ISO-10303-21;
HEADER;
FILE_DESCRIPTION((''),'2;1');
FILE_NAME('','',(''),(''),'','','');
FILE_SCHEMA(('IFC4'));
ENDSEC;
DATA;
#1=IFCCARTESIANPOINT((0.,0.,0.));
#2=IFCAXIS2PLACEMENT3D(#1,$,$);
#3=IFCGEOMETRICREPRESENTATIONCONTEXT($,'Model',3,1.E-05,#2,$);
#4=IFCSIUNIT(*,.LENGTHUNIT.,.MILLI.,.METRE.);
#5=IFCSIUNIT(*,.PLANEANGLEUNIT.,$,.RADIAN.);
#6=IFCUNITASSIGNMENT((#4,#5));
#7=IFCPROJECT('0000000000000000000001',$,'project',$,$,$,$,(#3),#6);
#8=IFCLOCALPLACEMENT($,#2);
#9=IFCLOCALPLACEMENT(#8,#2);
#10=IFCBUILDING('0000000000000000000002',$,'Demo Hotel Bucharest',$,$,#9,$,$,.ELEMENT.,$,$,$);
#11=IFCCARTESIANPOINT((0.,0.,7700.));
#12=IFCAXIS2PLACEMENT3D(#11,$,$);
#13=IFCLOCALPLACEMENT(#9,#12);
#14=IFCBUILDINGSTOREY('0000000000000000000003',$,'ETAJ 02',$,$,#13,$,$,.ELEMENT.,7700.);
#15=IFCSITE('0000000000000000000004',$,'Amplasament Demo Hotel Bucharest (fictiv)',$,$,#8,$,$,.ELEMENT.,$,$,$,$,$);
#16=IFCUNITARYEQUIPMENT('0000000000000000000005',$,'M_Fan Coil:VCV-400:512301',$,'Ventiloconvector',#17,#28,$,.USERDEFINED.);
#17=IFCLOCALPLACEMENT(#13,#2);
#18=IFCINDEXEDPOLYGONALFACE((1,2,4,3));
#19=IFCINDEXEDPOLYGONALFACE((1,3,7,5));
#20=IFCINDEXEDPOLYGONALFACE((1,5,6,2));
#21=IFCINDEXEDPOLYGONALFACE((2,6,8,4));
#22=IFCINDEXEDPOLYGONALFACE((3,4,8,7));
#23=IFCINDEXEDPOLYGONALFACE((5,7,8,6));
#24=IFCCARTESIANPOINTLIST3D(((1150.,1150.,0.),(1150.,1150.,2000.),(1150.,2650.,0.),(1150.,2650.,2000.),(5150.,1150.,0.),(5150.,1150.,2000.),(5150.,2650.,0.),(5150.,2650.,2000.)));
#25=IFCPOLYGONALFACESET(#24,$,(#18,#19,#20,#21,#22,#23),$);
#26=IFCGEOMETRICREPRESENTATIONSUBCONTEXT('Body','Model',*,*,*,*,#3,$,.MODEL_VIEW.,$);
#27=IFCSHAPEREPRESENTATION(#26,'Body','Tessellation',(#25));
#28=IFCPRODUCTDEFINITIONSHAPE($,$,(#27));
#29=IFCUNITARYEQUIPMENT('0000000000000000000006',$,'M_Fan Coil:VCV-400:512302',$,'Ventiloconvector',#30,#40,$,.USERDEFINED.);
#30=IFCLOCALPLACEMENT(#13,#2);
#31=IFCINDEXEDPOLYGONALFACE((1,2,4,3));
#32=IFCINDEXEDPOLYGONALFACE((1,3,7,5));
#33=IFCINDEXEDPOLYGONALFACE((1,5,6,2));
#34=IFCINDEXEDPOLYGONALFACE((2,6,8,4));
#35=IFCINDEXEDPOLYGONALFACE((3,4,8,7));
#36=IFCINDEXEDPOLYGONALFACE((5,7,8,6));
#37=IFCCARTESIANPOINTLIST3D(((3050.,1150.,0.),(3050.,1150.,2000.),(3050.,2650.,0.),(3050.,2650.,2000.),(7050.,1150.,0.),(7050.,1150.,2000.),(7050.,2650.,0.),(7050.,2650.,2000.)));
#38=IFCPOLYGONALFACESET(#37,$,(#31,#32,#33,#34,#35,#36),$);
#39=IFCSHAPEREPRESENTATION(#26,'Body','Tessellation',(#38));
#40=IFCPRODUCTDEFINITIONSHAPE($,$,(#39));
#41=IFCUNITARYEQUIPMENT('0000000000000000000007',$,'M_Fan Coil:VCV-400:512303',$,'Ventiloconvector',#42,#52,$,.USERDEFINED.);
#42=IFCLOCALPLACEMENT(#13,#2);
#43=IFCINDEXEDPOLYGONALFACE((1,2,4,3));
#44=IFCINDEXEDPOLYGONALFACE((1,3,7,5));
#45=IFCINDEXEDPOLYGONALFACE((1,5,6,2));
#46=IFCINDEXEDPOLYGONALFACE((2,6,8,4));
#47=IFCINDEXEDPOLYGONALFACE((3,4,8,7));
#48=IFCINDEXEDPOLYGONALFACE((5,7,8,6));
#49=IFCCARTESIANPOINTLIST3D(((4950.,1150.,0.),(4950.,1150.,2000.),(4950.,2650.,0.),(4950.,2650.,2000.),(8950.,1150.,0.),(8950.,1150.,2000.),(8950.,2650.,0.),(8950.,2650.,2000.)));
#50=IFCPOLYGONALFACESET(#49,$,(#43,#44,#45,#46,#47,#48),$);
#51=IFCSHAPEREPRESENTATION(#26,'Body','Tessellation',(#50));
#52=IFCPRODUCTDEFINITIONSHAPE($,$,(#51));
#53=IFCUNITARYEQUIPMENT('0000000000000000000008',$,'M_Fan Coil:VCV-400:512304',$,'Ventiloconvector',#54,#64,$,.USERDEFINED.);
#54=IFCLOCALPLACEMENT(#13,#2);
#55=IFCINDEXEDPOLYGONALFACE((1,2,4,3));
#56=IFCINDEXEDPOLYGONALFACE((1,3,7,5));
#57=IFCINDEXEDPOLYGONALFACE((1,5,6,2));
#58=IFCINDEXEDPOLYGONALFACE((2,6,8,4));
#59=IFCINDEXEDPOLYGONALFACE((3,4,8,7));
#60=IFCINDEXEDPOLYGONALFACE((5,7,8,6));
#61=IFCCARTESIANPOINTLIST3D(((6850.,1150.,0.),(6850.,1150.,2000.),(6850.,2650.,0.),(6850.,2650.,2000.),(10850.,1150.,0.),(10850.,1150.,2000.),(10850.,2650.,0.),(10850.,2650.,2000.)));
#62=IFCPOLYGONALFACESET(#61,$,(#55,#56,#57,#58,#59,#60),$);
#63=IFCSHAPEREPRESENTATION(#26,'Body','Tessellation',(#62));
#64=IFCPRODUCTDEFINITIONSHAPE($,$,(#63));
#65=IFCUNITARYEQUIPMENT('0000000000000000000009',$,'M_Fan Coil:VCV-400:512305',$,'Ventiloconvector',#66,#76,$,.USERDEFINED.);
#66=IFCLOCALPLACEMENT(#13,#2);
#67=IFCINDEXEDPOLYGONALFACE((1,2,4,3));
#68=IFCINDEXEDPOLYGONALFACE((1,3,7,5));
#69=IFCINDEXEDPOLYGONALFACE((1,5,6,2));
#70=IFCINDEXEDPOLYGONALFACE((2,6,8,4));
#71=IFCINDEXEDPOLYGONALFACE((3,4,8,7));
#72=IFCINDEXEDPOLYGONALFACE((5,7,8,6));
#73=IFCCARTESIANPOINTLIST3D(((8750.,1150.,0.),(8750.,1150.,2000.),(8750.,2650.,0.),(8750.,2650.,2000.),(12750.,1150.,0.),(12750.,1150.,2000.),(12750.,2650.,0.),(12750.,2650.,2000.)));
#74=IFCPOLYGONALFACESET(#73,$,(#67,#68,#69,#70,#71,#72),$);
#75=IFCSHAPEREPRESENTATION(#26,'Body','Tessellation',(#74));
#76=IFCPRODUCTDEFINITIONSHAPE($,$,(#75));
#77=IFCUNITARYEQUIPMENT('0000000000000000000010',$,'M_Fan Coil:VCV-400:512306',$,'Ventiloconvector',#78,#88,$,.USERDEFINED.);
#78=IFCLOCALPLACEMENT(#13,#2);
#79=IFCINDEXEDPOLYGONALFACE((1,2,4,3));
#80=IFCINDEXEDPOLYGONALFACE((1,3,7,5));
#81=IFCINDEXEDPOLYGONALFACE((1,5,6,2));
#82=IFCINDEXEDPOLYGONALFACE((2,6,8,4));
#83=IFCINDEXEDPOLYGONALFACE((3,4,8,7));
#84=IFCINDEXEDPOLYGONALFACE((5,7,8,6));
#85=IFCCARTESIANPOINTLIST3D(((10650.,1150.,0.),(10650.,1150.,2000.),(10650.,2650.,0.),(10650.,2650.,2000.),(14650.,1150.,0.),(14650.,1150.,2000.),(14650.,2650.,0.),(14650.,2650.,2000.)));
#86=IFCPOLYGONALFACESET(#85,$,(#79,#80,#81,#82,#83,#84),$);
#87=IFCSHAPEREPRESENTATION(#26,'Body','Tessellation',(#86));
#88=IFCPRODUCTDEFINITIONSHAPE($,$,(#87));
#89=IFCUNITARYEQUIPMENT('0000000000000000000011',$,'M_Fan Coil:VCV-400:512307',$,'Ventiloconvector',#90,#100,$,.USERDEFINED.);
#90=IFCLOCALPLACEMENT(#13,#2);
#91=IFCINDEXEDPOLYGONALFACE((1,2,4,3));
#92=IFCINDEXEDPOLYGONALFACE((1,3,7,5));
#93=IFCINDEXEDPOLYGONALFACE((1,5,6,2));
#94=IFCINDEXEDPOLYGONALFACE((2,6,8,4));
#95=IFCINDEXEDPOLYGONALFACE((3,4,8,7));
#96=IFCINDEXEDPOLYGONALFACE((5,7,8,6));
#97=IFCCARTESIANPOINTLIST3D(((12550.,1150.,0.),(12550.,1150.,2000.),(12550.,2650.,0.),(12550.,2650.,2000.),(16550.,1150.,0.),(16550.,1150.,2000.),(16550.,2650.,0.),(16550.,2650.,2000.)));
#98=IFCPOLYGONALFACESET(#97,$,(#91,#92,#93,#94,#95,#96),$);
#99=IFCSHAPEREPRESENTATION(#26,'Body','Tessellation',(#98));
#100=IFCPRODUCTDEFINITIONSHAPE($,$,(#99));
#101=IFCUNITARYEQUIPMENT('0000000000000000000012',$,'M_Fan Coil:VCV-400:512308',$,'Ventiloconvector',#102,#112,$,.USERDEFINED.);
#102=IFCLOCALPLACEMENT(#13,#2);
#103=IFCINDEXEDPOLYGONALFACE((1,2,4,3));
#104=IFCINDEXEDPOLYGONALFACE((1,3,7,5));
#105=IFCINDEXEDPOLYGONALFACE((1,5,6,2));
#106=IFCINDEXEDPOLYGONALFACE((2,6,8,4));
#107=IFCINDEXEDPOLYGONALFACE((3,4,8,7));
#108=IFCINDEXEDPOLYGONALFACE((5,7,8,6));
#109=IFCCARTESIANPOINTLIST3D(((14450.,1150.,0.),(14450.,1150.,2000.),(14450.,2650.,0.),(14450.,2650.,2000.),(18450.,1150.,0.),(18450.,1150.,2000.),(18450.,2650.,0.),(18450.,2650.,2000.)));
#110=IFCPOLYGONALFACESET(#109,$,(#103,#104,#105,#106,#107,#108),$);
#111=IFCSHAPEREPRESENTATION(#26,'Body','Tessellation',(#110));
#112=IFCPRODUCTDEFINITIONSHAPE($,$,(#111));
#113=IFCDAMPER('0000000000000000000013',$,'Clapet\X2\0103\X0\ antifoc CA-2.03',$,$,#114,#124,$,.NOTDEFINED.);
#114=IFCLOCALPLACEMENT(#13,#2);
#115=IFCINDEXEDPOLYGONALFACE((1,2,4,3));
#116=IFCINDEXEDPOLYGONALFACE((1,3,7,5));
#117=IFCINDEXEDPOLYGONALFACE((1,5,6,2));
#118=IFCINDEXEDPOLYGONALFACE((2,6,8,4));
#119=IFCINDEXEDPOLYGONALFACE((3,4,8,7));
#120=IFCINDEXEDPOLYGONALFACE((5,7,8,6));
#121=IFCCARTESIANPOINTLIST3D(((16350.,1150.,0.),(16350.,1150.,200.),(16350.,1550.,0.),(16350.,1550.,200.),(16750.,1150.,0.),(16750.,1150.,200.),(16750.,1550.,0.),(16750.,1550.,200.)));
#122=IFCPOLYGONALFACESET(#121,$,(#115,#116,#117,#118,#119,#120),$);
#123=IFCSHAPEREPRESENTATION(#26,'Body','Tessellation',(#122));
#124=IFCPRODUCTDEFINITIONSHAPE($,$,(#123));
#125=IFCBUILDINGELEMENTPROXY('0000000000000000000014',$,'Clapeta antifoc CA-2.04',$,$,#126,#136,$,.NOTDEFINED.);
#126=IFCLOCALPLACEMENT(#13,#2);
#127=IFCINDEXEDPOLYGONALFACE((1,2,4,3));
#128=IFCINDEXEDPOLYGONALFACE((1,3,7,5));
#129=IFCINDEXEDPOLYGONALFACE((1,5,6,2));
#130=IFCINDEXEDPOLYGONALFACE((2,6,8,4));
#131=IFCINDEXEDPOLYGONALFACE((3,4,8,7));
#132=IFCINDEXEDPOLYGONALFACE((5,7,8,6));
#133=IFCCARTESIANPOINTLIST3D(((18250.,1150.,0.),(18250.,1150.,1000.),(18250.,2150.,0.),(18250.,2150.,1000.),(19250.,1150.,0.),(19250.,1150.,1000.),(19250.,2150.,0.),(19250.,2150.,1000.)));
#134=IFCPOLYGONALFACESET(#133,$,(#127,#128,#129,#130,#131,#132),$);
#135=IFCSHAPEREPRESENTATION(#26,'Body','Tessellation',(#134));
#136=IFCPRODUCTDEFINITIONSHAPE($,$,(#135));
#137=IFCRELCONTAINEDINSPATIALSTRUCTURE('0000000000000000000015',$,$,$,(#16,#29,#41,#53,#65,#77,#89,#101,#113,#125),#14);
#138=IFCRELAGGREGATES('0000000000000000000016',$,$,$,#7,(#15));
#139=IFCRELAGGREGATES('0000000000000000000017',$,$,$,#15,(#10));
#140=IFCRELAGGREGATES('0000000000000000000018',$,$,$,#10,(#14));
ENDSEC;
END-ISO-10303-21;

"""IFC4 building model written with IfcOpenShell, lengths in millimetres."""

from ifc_helpers import new_model, si_unit, frame, frame_2d, origin, place, context, subcontext, project, spatial, rectangle, extrude, element, save


model = new_model("IFC4")

# Units and contexts
model_context = context("Model", 3, precision=1e-05, world=origin())
body_context = subcontext(model_context, "Body", "Model", "MODEL_VIEW")
ifc_project = project(units=[si_unit("LENGTHUNIT", "METRE", prefix="MILLI"), si_unit("PLANEANGLEUNIT", "RADIAN")], contexts=[model_context])

# Site, building, storey
site_placement = place(None, origin())
site = spatial("IfcSite", under=ifc_project, at=site_placement, Name="Amplasament Demo Hotel Bucharest (fictiv)", CompositionType="ELEMENT")
building_placement = place(site_placement, origin())
building = spatial("IfcBuilding", under=site, at=building_placement, Name="Demo Hotel Bucharest", CompositionType="ELEMENT")
storey_placement = place(building_placement, frame((0.0, 0.0, 7700.0)))
storey = spatial("IfcBuildingStorey", under=building, at=storey_placement, Name="ETAJ 02", CompositionType="ELEMENT", Elevation=7700.0)

# Unitary equipment
for number, where, name in (
    (1, (1150.0, 1150.0, 0.0), "M_Fan Coil:VCV-400:512301"),
    (2, (3050.0, 1150.0, 0.0), "M_Fan Coil:VCV-400:512302"),
    (3, (4950.0, 1150.0, 0.0), "M_Fan Coil:VCV-400:512303"),
    (4, (6850.0, 1150.0, 0.0), "M_Fan Coil:VCV-400:512304"),
    (5, (8750.0, 1150.0, 0.0), "M_Fan Coil:VCV-400:512305"),
    (6, (10650.0, 1150.0, 0.0), "M_Fan Coil:VCV-400:512306"),
    (7, (12550.0, 1150.0, 0.0), "M_Fan Coil:VCV-400:512307"),
    (8, (14450.0, 1150.0, 0.0), "M_Fan Coil:VCV-400:512308"),
):
    element("IfcUnitaryEquipment", number, at=place(storey_placement, frame(where)), inside=storey, Name=name, ObjectType="Ventiloconvector", PredefinedType="USERDEFINED", context=body_context, shape_type="SweptSolid", body=[
        extrude(rectangle(XDim=4000.0, YDim=1500.0, at=frame_2d((2000.0, 750.0))), origin(), (0.0, 0.0, 1.0), 2000.0),
    ])

# Damper
damper_placement = place(storey_placement, frame((16350.0, 1150.0, 0.0)))
element("IfcDamper", 9, at=damper_placement, inside=storey, Name="Clapetă antifoc CA-2.03", PredefinedType="NOTDEFINED", context=body_context, shape_type="SweptSolid", body=[
    extrude(rectangle(XDim=400.0, YDim=400.0, at=frame_2d((200.0, 200.0))), origin(), (0.0, 0.0, 1.0), 200.0),
])

# Building element proxy
proxy_placement = place(storey_placement, frame((18250.0, 1150.0, 0.0)))
element("IfcBuildingElementProxy", 10, at=proxy_placement, inside=storey, Name="Clapeta antifoc CA-2.04", PredefinedType="NOTDEFINED", context=body_context, shape_type="SweptSolid", body=[
    extrude(rectangle(XDim=1000.0, YDim=1000.0, at=frame_2d((500.0, 500.0))), origin(), (0.0, 0.0, 1.0), 1000.0),
])

save(model, "model.ifc")
